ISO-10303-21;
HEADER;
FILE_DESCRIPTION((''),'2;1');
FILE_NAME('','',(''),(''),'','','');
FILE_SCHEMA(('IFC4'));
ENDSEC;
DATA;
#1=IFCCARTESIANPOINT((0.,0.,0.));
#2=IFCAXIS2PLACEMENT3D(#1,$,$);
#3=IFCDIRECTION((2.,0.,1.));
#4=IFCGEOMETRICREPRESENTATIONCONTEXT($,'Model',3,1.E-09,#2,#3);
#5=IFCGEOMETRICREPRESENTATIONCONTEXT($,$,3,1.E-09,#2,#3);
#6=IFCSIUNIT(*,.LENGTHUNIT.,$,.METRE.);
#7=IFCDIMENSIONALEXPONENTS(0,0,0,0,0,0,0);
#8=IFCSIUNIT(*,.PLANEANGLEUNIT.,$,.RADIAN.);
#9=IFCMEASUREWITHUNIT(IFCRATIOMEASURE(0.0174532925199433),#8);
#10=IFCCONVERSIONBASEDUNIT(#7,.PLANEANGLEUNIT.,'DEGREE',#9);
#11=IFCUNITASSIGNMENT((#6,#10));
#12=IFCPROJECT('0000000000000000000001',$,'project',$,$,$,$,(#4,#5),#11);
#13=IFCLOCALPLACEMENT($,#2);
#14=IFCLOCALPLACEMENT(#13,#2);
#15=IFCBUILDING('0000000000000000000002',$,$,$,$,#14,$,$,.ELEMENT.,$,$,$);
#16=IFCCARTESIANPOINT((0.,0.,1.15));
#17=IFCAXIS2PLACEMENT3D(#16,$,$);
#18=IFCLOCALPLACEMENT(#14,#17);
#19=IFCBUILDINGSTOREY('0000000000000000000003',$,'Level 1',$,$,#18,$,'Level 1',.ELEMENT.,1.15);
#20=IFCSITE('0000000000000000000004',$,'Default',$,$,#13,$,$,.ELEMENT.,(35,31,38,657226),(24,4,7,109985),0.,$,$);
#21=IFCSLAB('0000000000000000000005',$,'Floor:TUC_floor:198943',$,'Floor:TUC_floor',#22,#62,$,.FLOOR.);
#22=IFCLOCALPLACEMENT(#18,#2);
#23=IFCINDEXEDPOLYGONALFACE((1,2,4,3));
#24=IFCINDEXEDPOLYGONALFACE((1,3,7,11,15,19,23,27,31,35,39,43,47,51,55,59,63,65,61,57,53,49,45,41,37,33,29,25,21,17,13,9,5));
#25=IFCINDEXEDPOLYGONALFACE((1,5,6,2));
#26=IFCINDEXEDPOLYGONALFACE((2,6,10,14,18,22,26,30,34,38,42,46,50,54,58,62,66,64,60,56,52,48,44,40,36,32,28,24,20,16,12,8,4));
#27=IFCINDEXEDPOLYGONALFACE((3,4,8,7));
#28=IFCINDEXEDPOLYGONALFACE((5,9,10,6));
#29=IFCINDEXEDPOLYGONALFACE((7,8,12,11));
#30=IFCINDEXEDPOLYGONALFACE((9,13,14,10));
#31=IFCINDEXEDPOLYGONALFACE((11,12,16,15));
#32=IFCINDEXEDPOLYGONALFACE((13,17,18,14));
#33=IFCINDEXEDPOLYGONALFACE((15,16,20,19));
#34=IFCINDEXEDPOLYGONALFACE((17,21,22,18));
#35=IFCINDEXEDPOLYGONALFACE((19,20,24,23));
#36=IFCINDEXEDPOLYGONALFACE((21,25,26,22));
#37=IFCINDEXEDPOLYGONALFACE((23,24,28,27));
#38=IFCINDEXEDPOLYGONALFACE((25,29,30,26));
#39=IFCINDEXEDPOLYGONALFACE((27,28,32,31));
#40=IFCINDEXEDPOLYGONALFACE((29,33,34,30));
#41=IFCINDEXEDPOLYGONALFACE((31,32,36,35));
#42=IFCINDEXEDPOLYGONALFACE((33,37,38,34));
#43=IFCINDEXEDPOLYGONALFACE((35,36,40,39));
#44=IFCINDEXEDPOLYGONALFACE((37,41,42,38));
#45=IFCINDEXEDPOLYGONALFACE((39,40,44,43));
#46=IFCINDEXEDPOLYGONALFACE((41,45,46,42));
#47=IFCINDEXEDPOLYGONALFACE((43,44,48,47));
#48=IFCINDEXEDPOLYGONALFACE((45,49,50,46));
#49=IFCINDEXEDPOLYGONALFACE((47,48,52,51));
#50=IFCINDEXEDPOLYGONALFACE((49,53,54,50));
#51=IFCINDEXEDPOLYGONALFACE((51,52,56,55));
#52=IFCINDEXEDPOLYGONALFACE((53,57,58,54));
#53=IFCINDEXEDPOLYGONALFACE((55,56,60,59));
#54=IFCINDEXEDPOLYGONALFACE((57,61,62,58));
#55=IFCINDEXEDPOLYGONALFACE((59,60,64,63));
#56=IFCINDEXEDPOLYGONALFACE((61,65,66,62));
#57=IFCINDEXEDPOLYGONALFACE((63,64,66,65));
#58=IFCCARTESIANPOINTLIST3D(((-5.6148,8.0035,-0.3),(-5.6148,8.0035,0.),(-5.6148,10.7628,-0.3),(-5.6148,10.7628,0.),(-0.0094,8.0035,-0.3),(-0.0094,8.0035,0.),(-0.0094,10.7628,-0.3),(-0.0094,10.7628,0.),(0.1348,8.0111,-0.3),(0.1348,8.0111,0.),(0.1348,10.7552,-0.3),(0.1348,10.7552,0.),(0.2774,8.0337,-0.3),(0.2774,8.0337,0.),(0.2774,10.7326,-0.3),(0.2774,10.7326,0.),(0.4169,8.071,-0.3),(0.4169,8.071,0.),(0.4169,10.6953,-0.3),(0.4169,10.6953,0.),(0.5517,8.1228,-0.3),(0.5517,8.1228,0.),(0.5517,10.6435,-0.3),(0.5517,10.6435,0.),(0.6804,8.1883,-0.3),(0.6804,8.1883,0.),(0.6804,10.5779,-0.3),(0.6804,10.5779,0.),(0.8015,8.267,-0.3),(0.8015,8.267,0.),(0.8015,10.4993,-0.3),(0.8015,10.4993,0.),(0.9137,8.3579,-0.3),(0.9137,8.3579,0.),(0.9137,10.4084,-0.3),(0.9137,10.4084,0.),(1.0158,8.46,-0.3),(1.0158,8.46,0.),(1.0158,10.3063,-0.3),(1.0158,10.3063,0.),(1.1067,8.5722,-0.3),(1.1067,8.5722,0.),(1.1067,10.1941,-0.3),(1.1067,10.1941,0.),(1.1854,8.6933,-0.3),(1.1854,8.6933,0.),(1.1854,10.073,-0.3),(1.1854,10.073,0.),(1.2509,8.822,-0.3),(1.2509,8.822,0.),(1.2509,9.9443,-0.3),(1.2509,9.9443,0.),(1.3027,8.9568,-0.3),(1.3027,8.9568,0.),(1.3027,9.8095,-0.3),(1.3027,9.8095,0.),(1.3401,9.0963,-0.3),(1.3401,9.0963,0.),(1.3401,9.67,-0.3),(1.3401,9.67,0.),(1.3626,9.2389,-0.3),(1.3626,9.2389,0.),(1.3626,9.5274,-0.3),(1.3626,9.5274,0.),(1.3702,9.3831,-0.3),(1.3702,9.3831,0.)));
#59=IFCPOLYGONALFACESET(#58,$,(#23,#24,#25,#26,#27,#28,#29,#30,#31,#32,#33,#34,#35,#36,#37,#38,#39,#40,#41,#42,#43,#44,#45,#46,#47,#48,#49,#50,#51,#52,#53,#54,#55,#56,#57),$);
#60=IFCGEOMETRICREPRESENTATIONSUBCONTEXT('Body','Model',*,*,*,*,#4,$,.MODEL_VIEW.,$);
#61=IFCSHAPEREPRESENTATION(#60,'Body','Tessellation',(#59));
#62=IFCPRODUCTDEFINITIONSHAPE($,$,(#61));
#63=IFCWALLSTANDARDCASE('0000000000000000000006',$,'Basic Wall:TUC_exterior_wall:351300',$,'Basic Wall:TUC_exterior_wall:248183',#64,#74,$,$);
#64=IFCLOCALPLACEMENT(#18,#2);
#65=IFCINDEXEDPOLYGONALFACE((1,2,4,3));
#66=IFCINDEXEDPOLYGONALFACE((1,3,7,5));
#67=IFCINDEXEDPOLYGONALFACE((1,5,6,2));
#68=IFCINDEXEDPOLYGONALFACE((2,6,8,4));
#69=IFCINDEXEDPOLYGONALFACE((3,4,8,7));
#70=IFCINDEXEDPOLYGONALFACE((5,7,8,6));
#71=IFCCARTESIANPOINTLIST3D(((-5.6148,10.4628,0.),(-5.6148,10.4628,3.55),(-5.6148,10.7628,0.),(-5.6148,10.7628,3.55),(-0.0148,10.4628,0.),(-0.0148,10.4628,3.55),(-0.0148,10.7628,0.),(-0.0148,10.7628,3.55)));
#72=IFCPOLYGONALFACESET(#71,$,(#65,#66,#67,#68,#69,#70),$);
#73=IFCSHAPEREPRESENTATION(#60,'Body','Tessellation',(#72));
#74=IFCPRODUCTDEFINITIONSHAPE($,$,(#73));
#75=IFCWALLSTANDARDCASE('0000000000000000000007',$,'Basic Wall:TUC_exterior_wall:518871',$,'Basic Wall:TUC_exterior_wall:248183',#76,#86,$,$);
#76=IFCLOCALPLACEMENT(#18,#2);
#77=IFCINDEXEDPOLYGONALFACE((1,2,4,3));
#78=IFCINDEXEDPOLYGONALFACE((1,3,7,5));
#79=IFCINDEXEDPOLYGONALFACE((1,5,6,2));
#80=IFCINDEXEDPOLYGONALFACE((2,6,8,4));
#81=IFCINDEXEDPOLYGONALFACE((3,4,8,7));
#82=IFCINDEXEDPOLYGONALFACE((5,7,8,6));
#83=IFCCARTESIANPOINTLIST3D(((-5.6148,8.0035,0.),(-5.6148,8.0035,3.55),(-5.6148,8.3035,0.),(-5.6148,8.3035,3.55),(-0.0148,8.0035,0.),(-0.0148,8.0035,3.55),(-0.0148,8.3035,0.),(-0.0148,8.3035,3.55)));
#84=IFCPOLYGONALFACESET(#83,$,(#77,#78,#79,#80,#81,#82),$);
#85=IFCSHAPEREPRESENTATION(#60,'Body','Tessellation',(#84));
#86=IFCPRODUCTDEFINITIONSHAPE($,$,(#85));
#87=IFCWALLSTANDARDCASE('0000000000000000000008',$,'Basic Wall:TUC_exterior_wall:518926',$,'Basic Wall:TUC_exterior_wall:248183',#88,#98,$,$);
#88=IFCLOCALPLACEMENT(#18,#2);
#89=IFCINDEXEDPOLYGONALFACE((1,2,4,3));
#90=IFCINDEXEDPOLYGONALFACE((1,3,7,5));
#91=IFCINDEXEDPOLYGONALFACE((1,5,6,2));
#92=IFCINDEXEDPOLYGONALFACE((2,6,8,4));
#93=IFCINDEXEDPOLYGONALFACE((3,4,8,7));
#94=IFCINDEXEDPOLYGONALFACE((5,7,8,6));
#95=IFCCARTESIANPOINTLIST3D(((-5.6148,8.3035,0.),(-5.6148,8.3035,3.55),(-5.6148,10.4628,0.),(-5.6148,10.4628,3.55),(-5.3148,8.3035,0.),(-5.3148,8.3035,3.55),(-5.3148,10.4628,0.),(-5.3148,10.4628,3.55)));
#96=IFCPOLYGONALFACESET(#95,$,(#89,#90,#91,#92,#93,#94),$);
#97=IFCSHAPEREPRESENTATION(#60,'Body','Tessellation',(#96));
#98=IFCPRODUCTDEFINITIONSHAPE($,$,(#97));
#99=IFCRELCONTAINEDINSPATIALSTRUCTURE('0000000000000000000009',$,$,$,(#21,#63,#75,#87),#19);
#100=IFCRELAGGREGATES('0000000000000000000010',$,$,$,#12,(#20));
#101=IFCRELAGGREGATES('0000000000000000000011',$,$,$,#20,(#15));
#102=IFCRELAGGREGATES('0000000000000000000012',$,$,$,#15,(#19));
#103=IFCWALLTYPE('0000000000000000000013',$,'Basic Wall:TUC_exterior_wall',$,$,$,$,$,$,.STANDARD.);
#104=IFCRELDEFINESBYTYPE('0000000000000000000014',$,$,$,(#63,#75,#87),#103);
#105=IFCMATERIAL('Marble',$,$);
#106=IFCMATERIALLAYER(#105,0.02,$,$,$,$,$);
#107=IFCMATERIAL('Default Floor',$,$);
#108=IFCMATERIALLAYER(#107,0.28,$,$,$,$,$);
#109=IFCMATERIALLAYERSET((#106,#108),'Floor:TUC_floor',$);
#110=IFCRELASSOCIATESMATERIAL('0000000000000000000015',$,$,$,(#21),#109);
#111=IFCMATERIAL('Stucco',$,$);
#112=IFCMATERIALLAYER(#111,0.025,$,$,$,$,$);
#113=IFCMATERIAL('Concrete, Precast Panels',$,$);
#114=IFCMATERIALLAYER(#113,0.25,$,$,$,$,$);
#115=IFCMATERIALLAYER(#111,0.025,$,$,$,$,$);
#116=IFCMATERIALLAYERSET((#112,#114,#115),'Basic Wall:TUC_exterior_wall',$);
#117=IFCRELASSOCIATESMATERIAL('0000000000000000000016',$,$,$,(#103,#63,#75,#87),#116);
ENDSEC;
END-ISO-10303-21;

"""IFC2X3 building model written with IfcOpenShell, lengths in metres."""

from ifc_helpers import new_model, entity, si_unit, converted_unit, direction, frame, frame_2d, origin, place, context, subcontext, project, spatial, polyline, circle_curve, parameter, trimmed, segment, composite_curve, rectangle, outline, extrude, material, layer, layer_set, layer_usage, type_object, element, save


model = new_model("IFC2X3")

# Units and contexts
model_context = context("Model", 3, precision=1e-09, world=origin(), true_north=direction((2.0, 0.0, 1.0)))
context_of_model = context(None, 3, precision=1e-09, world=origin(), true_north=direction((2.0, 0.0, 1.0)))
body_context = subcontext(model_context, "Body", "Model", "MODEL_VIEW")
ifc_project = project(units=[si_unit("LENGTHUNIT", "METRE"), converted_unit("PLANEANGLEUNIT", "DEGREE", entity("IfcRatioMeasure", 0.0174532925199433), si_unit("PLANEANGLEUNIT", "RADIAN"), dimensions=[0, 0, 0, 0, 0, 0, 0])], contexts=[model_context, context_of_model])

# Site, building, storey
site_placement = place(None, origin())
site = spatial("IfcSite", under=ifc_project, at=site_placement, Name="Default", CompositionType="ELEMENT", RefLatitude=(35, 31, 38, 657226), RefLongitude=(24, 4, 7, 109985), RefElevation=0.0)
building_placement = place(site_placement, origin())
building = spatial("IfcBuilding", under=site, at=building_placement, CompositionType="ELEMENT")
storey_placement = place(building_placement, frame((0.0, 0.0, 1.15)))
storey = spatial("IfcBuildingStorey", under=building, at=storey_placement, Name="Level 1", LongName="Level 1", CompositionType="ELEMENT", Elevation=1.15)

# Slab
ifc_material_1 = material(Name="Marble")
ifc_layer_1 = layer(ifc_material_1, 0.02)
ifc_material_2 = material(Name="Default Floor")
ifc_layer_2 = layer(ifc_material_2, 0.28)
ifc_layer_set_1 = layer_set([ifc_layer_1, ifc_layer_2], Name="Floor:TUC_floor")
ifc_layer_usage_1 = layer_usage(ifc_layer_set_1, "AXIS3", "POSITIVE", 0.0)
slab_placement = place(storey_placement, origin())
element("IfcSlab", 1, at=slab_placement, inside=storey, material=ifc_layer_usage_1, Name="Floor:TUC_floor:198943", ObjectType="Floor:TUC_floor", PredefinedType="FLOOR", context=body_context, shape_type="SweptSolid", body=[
    extrude(outline(composite_curve([segment(polyline([(-1.3796, -2.8027), (1.3796, -2.8027)]), True, "CONTINUOUS"), segment(polyline([(1.3796, -2.8027), (1.3796, 2.8027)]), True, "CONTINUOUS"), segment(trimmed(circle_curve(frame_2d((0.0, 2.8027), x_axis=(1.0, 0.0)), 1.3796), [parameter(0.0)], [parameter(180.0)], True, "PARAMETER"), True, "CONTINUOUS"), segment(polyline([(-1.3796, 2.8027), (-1.3796, -2.8027)]), True, "CONTINUOUS")], self_intersect=False)), frame((-2.8121, 9.3831, 0.0), z_axis=(0.0, 0.0, -1.0), x_axis=(0.0, 1.0, 0.0)), (0.0, 0.0, 1.0), 0.3),
])

# Walls
ifc_material_3 = material(Name="Stucco")
ifc_layer_3 = layer(ifc_material_3, 0.025)
ifc_material_4 = material(Name="Concrete, Precast Panels")
ifc_layer_4 = layer(ifc_material_4, 0.25)
ifc_layer_5 = layer(ifc_material_3, 0.025)
ifc_layer_set_2 = layer_set([ifc_layer_3, ifc_layer_4, ifc_layer_5], Name="Basic Wall:TUC_exterior_wall")
ifc_layer_usage_2 = layer_usage(ifc_layer_set_2, "AXIS2", "NEGATIVE", 0.15)
wall_type = type_object("IfcWallType", Name="Basic Wall:TUC_exterior_wall", PredefinedType="STANDARD", material=ifc_layer_set_2)
wall_1_placement = place(storey_placement, frame((-0.0148, 10.6128, 0.0), z_axis=(0.0, 0.0, 1.0), x_axis=(-1.0, 0.0, 0.0)))
element("IfcWallStandardCase", 2, at=wall_1_placement, inside=storey, type_object=wall_type, material=ifc_layer_usage_2, Name="Basic Wall:TUC_exterior_wall:351300", ObjectType="Basic Wall:TUC_exterior_wall:248183", context=body_context, shape_type="SweptSolid", body=[
    extrude(rectangle(XDim=5.6, YDim=0.3, at=frame_2d((2.8, 0.0), x_axis=(-1.0, 0.0))), origin(), (0.0, 0.0, 1.0), 3.55),
])
ifc_layer_usage_3 = layer_usage(ifc_layer_set_2, "AXIS2", "NEGATIVE", 0.15)
wall_2_placement = place(storey_placement, frame((-0.0148, 8.1535, 0.0), z_axis=(0.0, 0.0, 1.0), x_axis=(-1.0, 0.0, 0.0)))
element("IfcWallStandardCase", 3, at=wall_2_placement, inside=storey, type_object=wall_type, material=ifc_layer_usage_3, Name="Basic Wall:TUC_exterior_wall:518871", ObjectType="Basic Wall:TUC_exterior_wall:248183", context=body_context, shape_type="SweptSolid", body=[
    extrude(rectangle(XDim=5.6, YDim=0.3, at=frame_2d((2.8, 0.0), x_axis=(-1.0, 0.0))), origin(), (0.0, 0.0, 1.0), 3.55),
])
ifc_layer_usage_4 = layer_usage(ifc_layer_set_2, "AXIS2", "NEGATIVE", 0.15)
wall_3_placement = place(storey_placement, frame((-5.4648, 8.3035, 0.0), z_axis=(0.0, 0.0, 1.0), x_axis=(0.0, 1.0, 0.0)))
element("IfcWallStandardCase", 4, at=wall_3_placement, inside=storey, type_object=wall_type, material=ifc_layer_usage_4, Name="Basic Wall:TUC_exterior_wall:518926", ObjectType="Basic Wall:TUC_exterior_wall:248183", context=body_context, shape_type="SweptSolid", body=[
    extrude(rectangle(XDim=2.1593, YDim=0.3, at=frame_2d((1.0796, 0.0), x_axis=(-1.0, 0.0))), origin(), (0.0, 0.0, 1.0), 3.55),
])

save(model, "model.ifc")
